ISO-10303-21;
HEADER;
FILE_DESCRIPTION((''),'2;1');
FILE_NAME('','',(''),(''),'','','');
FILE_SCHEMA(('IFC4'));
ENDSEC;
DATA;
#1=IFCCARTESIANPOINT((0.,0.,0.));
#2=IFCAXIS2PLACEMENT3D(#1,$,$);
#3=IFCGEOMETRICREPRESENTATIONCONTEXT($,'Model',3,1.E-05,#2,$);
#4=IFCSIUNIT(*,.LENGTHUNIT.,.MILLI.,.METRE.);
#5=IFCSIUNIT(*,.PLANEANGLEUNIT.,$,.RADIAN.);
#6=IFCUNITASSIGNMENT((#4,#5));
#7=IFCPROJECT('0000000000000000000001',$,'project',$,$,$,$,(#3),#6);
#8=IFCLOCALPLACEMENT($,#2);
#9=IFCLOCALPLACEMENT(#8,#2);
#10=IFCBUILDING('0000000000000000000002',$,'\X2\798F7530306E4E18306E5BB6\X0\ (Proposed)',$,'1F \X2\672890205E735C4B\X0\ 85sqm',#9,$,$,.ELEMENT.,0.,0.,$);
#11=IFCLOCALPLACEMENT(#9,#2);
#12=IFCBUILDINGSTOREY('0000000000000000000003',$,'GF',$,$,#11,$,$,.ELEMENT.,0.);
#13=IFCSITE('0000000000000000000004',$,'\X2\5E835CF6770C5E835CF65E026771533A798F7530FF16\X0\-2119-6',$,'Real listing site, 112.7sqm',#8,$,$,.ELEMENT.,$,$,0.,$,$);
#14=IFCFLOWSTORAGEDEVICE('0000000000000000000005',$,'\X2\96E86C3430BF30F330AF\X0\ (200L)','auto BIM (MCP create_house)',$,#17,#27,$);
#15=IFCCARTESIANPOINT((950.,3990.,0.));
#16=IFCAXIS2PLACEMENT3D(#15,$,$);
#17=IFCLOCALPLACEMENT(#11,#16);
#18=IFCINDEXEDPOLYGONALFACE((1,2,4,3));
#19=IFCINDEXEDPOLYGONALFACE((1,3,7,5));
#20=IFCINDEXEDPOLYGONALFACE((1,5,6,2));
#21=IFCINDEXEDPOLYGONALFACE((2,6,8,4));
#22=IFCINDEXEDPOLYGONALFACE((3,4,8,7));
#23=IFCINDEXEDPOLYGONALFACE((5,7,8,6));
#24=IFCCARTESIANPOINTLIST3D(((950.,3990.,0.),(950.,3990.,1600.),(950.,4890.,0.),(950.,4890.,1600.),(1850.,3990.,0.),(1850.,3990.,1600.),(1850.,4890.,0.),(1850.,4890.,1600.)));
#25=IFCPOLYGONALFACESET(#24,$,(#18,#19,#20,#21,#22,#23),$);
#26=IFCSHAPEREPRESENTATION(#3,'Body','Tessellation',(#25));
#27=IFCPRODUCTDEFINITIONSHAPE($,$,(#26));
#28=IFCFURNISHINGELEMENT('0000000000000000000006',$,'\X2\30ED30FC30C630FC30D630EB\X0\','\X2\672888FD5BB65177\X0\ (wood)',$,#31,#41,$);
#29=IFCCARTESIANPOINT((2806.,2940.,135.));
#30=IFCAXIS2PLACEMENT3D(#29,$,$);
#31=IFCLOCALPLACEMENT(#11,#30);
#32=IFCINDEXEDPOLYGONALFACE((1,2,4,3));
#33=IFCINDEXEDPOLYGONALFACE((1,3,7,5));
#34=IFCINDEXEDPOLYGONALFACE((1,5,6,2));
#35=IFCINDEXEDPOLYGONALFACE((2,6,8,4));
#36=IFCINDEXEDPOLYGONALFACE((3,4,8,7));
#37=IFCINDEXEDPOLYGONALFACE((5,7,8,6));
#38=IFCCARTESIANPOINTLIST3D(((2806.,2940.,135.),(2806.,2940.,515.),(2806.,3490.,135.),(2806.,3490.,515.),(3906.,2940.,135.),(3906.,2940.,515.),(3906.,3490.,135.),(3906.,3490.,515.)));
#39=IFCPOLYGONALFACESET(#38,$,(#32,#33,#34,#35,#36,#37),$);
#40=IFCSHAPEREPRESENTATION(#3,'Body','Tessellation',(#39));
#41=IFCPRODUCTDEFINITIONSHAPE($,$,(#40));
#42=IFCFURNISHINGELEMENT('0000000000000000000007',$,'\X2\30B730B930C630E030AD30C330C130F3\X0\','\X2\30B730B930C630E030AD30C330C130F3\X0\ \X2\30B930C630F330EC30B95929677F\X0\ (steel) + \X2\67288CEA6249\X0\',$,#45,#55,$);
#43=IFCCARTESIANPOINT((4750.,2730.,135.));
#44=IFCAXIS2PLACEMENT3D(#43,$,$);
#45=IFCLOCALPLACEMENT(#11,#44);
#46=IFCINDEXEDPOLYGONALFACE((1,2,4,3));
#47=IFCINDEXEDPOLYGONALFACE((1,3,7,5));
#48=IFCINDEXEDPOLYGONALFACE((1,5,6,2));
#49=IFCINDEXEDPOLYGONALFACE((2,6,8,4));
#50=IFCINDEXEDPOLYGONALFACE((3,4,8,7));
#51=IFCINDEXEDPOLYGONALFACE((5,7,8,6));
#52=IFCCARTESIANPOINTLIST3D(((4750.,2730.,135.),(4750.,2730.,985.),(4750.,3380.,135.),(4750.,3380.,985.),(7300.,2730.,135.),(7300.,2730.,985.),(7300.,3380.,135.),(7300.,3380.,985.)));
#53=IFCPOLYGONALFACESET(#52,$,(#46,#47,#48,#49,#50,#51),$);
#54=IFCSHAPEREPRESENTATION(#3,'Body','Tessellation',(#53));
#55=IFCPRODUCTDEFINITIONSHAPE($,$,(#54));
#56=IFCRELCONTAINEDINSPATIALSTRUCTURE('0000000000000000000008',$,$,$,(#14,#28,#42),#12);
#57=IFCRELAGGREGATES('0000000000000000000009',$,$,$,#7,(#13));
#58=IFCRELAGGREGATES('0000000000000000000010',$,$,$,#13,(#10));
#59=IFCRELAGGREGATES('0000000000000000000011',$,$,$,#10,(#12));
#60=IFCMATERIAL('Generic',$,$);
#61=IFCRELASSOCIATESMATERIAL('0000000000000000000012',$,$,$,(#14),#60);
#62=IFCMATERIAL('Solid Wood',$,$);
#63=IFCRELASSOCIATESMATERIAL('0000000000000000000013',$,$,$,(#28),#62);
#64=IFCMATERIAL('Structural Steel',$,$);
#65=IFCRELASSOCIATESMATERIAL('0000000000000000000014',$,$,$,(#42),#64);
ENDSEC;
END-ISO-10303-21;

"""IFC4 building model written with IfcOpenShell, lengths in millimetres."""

from ifc_helpers import new_model, si_unit, frame, frame_2d, origin, place, context, project, spatial, rectangle, extrude, material, element, save


model = new_model("IFC4")

# Units and contexts
model_context = context("Model", 3, precision=1e-05, world=origin())
ifc_project = project(units=[si_unit("LENGTHUNIT", "METRE", prefix="MILLI"), si_unit("PLANEANGLEUNIT", "RADIAN")], contexts=[model_context])

# Site, building, storey
site_placement = place(None, origin())
site = spatial("IfcSite", under=ifc_project, at=site_placement, Name="広島県広島市東区福田６-2119-6", ObjectType="Real listing site, 112.7sqm", CompositionType="ELEMENT", RefElevation=0.0)
building_placement = place(site_placement, origin())
building = spatial("IfcBuilding", under=site, at=building_placement, Name="福田の丘の家 (Proposed)", ObjectType="1F 木造平屋 85sqm", CompositionType="ELEMENT", ElevationOfRefHeight=0.0, ElevationOfTerrain=0.0)
storey_placement = place(building_placement, origin())
storey = spatial("IfcBuildingStorey", under=building, at=storey_placement, Name="GF", CompositionType="ELEMENT", Elevation=0.0)

# Shared definitions
ifc_material_1 = material(Name="Solid Wood")

# Shared definitions
ifc_material_2 = material(Name="Generic")

# Flow storage device
flow_storage_device_placement = place(storey_placement, frame((950.0, 3990.0, 0.0)))
element("IfcFlowStorageDevice", 1, at=flow_storage_device_placement, inside=storey, material=ifc_material_2, Name="雨水タンク (200L)", Description="auto BIM (MCP create_house)", context=model_context, shape_type="SweptSolid", body=[
    extrude(rectangle(XDim=900.0, YDim=900.0, at=frame_2d((450.0, 450.0))), frame((950.0, 3990.0, 0.0)), (0.0, 0.0, 1.0), 1600.0),
])

# Furnishing elements
furnishing_1_placement = place(storey_placement, frame((2806.0, 2940.0, 135.0)))
element("IfcFurnishingElement", 2, at=furnishing_1_placement, inside=storey, material=ifc_material_1, Name="ローテーブル", Description="木製家具 (wood)", context=model_context, shape_type="SweptSolid", body=[
    extrude(rectangle(XDim=1100.0, YDim=550.0, at=frame_2d((550.0, 275.0))), frame((2806.0, 2940.0, 135.0)), (0.0, 0.0, 1.0), 380.0),
])
ifc_material_3 = material(Name="Structural Steel")
furnishing_2_placement = place(storey_placement, frame((4750.0, 2730.0, 135.0)))
element("IfcFurnishingElement", 3, at=furnishing_2_placement, inside=storey, material=ifc_material_3, Name="システムキッチン", Description="システムキッチン ステンレス天板 (steel) + 木質扉", context=model_context, shape_type="SweptSolid", body=[
    extrude(rectangle(XDim=2550.0, YDim=650.0, at=frame_2d((1275.0, 325.0))), frame((4750.0, 2730.0, 135.0)), (0.0, 0.0, 1.0), 850.0),
])

save(model, "model.ifc")
